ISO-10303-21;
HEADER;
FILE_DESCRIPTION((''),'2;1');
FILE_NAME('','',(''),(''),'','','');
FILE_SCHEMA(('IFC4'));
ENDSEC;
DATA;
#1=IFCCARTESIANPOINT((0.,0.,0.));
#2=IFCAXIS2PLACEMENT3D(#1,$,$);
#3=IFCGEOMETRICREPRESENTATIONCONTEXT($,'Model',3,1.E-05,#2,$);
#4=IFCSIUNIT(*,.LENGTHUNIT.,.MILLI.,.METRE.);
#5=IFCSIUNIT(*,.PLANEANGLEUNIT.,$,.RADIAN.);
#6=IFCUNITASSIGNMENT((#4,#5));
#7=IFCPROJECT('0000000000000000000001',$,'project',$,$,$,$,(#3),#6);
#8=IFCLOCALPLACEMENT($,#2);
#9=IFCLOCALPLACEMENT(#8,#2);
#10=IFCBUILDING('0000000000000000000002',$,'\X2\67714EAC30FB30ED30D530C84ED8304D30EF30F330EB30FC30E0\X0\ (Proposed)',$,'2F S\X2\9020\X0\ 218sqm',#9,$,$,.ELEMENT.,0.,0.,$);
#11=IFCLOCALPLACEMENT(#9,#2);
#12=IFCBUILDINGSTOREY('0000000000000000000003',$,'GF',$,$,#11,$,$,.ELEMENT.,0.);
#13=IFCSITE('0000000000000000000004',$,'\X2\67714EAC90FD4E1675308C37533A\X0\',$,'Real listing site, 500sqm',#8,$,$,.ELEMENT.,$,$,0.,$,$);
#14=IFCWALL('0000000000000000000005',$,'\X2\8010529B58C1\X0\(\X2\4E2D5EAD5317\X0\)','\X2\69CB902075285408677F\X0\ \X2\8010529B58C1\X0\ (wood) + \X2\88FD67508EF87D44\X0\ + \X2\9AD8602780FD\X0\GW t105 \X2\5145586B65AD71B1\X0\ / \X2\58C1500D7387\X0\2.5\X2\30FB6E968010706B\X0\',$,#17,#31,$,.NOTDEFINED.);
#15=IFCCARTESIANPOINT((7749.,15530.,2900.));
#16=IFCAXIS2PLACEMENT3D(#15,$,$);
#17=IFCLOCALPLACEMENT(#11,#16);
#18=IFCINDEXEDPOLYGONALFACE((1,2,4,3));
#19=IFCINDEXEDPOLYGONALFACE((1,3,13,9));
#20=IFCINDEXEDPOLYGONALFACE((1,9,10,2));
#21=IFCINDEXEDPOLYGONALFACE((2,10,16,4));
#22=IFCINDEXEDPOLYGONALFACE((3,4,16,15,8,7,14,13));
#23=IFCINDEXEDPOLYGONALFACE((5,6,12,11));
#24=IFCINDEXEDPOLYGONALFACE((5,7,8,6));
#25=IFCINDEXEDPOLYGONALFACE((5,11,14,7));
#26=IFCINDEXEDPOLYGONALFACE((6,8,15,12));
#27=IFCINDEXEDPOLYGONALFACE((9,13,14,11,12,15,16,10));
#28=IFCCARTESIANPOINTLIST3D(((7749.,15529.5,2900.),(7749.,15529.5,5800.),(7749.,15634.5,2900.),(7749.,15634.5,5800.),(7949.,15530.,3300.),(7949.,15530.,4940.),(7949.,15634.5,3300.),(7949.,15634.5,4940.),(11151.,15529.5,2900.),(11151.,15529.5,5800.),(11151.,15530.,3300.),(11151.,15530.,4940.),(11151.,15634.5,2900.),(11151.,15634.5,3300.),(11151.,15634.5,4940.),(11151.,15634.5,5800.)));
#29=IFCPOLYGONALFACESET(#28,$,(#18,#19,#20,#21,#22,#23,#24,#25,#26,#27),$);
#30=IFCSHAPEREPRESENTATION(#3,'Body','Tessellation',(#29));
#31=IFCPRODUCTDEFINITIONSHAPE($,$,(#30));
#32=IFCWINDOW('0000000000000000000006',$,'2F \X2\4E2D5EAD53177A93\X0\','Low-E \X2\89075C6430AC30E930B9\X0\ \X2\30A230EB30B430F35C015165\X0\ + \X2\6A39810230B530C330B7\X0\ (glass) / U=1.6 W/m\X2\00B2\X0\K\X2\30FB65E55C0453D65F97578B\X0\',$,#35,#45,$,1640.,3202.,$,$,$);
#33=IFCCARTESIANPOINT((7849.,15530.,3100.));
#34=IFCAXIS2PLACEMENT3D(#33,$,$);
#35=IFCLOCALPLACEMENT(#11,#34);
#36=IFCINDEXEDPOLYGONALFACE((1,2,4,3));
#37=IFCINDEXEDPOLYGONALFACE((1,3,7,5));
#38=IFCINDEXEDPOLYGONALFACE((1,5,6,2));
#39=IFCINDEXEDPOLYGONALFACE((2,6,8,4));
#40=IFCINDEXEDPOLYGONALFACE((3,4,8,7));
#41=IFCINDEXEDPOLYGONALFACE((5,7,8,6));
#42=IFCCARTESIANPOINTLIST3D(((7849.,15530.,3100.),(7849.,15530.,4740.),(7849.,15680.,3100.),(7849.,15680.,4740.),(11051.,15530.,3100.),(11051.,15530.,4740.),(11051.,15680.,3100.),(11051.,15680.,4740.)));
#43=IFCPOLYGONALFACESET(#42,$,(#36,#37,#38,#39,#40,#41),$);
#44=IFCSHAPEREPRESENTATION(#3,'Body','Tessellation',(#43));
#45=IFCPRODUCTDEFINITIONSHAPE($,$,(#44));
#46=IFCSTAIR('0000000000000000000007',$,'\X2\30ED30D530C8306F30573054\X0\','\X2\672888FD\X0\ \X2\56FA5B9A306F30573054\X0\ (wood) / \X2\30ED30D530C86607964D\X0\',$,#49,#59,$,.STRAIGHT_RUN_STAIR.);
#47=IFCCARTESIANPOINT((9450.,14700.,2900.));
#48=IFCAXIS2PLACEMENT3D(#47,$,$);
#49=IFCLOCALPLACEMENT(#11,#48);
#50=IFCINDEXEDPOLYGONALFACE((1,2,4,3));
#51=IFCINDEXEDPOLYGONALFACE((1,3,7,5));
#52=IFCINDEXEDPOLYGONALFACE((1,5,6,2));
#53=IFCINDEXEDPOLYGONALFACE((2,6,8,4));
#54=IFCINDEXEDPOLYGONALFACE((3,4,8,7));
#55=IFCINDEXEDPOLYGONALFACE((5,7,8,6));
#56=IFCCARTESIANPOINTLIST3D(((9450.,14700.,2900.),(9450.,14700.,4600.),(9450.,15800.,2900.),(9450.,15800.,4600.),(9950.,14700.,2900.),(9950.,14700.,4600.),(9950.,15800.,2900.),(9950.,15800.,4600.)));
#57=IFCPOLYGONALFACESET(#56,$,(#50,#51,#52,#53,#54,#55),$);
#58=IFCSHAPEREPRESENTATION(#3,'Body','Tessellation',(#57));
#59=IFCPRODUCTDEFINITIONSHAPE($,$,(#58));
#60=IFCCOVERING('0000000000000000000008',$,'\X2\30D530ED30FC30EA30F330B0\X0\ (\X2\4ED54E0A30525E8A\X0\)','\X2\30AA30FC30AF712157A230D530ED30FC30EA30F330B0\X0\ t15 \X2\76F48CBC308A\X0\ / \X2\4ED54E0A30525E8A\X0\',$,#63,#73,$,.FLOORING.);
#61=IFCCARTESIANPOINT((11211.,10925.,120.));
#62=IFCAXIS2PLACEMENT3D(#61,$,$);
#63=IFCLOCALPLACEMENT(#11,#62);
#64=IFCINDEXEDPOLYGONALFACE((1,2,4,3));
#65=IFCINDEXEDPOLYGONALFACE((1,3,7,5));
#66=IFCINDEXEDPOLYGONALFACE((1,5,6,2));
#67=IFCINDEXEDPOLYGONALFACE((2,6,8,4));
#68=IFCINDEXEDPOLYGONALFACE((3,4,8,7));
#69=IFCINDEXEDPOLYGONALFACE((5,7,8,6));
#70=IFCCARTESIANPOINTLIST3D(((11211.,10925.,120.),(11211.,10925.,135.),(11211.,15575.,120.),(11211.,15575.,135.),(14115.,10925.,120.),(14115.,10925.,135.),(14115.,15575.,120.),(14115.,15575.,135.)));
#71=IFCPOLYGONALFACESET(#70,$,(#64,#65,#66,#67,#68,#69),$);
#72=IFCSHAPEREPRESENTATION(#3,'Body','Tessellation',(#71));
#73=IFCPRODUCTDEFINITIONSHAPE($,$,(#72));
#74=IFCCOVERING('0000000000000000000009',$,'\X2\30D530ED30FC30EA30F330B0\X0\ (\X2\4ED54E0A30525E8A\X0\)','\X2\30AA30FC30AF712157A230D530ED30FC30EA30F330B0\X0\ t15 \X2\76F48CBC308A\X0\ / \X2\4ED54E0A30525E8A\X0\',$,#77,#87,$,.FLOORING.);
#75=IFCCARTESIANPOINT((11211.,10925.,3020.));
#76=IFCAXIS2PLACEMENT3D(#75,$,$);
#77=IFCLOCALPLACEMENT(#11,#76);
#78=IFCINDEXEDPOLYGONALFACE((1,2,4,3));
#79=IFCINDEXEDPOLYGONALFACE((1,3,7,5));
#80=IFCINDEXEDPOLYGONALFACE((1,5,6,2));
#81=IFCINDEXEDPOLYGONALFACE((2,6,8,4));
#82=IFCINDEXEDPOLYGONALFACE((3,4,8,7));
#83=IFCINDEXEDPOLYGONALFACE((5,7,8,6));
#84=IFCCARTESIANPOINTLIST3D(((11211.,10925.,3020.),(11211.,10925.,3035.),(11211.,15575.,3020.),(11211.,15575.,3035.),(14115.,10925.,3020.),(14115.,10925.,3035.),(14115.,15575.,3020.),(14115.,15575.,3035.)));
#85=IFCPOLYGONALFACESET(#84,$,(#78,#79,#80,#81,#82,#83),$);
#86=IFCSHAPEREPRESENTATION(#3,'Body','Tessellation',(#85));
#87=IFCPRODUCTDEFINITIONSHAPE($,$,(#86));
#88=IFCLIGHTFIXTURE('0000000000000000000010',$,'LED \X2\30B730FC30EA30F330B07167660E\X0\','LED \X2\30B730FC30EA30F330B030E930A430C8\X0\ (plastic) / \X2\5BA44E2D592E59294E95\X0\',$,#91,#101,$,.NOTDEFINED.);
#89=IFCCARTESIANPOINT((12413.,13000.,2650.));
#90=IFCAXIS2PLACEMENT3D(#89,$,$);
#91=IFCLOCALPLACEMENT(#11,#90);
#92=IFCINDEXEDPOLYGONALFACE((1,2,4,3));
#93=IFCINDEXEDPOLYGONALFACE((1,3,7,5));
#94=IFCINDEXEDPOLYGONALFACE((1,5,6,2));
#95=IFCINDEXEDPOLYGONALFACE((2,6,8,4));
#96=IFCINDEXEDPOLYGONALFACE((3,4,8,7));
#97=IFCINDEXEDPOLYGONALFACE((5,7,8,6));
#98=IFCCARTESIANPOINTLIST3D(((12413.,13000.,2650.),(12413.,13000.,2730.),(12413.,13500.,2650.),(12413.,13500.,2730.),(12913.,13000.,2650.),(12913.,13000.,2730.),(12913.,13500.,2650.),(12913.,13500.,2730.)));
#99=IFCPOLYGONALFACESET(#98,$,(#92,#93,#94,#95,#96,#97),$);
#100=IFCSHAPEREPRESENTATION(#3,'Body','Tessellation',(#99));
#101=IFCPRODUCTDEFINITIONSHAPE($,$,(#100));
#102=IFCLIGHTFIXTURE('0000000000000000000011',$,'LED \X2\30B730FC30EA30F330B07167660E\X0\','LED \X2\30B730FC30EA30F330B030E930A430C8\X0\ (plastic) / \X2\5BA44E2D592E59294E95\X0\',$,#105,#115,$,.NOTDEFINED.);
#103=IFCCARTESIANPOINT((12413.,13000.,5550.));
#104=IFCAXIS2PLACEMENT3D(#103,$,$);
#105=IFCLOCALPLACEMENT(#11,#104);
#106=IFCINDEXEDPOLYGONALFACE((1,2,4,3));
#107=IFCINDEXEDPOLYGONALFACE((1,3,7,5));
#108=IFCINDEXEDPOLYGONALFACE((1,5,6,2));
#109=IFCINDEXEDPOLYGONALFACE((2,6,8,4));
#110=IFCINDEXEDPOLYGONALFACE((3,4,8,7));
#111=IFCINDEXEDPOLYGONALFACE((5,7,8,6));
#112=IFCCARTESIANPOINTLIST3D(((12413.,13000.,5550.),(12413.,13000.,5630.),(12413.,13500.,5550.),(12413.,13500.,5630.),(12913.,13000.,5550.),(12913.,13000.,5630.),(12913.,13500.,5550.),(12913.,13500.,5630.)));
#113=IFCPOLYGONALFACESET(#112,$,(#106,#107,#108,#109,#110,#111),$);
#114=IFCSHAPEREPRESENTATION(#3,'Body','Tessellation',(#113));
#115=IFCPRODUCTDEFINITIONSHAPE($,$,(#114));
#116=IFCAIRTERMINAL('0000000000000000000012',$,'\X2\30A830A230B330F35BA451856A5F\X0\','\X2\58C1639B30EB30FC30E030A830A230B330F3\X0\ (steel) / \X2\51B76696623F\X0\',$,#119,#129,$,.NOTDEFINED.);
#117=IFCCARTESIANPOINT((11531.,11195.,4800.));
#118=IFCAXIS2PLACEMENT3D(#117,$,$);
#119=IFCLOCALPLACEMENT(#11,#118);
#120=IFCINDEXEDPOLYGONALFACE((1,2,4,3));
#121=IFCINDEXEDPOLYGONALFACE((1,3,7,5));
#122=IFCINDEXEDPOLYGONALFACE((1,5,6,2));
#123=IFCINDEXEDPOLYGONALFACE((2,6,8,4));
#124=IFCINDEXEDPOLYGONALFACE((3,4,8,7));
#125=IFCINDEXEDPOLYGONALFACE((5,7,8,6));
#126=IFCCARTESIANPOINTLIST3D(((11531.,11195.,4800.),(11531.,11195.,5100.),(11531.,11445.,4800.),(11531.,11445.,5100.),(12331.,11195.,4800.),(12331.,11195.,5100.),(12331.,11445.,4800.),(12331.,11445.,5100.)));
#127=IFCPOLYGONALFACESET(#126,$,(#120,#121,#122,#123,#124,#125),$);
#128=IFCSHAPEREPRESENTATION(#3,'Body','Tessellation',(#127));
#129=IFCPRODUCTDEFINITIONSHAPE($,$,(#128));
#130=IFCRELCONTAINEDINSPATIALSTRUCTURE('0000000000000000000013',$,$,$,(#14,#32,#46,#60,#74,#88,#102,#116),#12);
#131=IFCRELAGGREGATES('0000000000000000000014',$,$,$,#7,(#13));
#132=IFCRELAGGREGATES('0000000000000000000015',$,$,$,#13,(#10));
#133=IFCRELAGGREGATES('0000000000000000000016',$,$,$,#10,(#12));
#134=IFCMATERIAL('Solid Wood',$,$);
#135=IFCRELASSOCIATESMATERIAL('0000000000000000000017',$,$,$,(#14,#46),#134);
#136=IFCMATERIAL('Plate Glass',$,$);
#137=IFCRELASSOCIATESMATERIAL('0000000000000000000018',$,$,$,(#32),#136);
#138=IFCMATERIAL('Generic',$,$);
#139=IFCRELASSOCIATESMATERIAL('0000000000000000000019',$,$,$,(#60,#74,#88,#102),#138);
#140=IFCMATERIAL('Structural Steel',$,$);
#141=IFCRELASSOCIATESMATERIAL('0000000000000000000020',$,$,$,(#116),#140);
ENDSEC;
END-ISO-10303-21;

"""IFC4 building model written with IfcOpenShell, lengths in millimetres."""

from ifc_helpers import new_model, si_unit, frame, frame_2d, origin, place, context, project, spatial, rectangle, extrude, material, element, fill, save


model = new_model("IFC4")

# Units and contexts
model_context = context("Model", 3, precision=1e-05, world=origin())
ifc_project = project(units=[si_unit("LENGTHUNIT", "METRE", prefix="MILLI"), si_unit("PLANEANGLEUNIT", "RADIAN")], contexts=[model_context])

# Site, building, storey
site_placement = place(None, origin())
site = spatial("IfcSite", under=ifc_project, at=site_placement, Name="東京都世田谷区", ObjectType="Real listing site, 500sqm", CompositionType="ELEMENT", RefElevation=0.0)
building_placement = place(site_placement, origin())
building = spatial("IfcBuilding", under=site, at=building_placement, Name="東京・ロフト付きワンルーム (Proposed)", ObjectType="2F S造 218sqm", CompositionType="ELEMENT", ElevationOfRefHeight=0.0, ElevationOfTerrain=0.0)
storey_placement = place(building_placement, origin())
storey = spatial("IfcBuildingStorey", under=building, at=storey_placement, Name="GF", CompositionType="ELEMENT", Elevation=0.0)

# Shared definitions
ifc_material_1 = material(Name="Solid Wood")

# Wall, opening, window
ifc_material_2 = material(Name="Plate Glass")
wall_1_placement = place(storey_placement, frame((7749.0, 15530.0, 2900.0)))
wall_1 = element("IfcWall", 1, at=wall_1_placement, inside=storey, material=ifc_material_1, Name="耐力壁(中庭北)", Description="構造用合板 耐力壁 (wood) + 製材軸組 + 高性能GW t105 充填断熱 / 壁倍率2.5・準耐火", PredefinedType="NOTDEFINED", context=model_context, shape_type="SweptSolid", body=[
    extrude(rectangle(XDim=3402.0, YDim=105.0, at=frame_2d((1701.0, 52.0))), frame((7749.0, 15530.0, 2900.0)), (0.0, 0.0, 1.0), 2900.0),
])
opening_1_placement = place(storey_placement, frame((7849.0, 15530.0, 3100.0)))
opening_1 = element("IfcOpeningElement", 2, at=opening_1_placement, cuts=wall_1, PredefinedType="NOTDEFINED", context=model_context, shape_type="SweptSolid", body=[
    extrude(rectangle(XDim=3202.0, YDim=150.0, at=frame_2d((1601.0, 75.0))), frame((7849.0, 15530.0, 3100.0)), (0.0, 0.0, 1.0), 1640.0),
])
window_1_placement = place(storey_placement, frame((7849.0, 15530.0, 3100.0)))
window_1 = element("IfcWindow", 3, at=window_1_placement, inside=storey, material=ifc_material_2, Name="2F 中庭北窓", Description="Low-E 複層ガラス アルゴン封入 + 樹脂サッシ (glass) / U=1.6 W/m²K・日射取得型", OverallHeight=1640.0, OverallWidth=3202.0, context=model_context, shape_type="SweptSolid", body=[
    extrude(rectangle(XDim=3202.0, YDim=150.0, at=frame_2d((1601.0, 75.0))), frame((7849.0, 15530.0, 3100.0)), (0.0, 0.0, 1.0), 1640.0),
])
fill(opening_1, window_1)

# Stair
stair_placement = place(storey_placement, frame((9450.0, 14700.0, 2900.0)))
element("IfcStair", 4, at=stair_placement, inside=storey, material=ifc_material_1, Name="ロフトはしご", Description="木製 固定はしご (wood) / ロフト昇降", PredefinedType="STRAIGHT_RUN_STAIR", context=model_context, shape_type="SweptSolid", body=[
    extrude(rectangle(XDim=500.0, YDim=1100.0, at=frame_2d((250.0, 550.0))), frame((9450.0, 14700.0, 2900.0)), (0.0, 0.0, 1.0), 1700.0),
])

# Coverings
ifc_material_3 = material(Name="Generic")
covering_1_placement = place(storey_placement, frame((11211.0, 10925.0, 120.0)))
element("IfcCovering", 5, at=covering_1_placement, inside=storey, material=ifc_material_3, Name="フローリング (仕上げ床)", Description="オーク無垢フローリング t15 直貼り / 仕上げ床", PredefinedType="FLOORING", context=model_context, shape_type="SweptSolid", body=[
    extrude(rectangle(XDim=2904.0, YDim=4650.0, at=frame_2d((1452.0, 2325.0))), frame((11211.0, 10925.0, 120.0)), (0.0, 0.0, 1.0), 15.0),
])
covering_2_placement = place(storey_placement, frame((11211.0, 10925.0, 3020.0)))
element("IfcCovering", 6, at=covering_2_placement, inside=storey, material=ifc_material_3, Name="フローリング (仕上げ床)", Description="オーク無垢フローリング t15 直貼り / 仕上げ床", PredefinedType="FLOORING", context=model_context, shape_type="SweptSolid", body=[
    extrude(rectangle(XDim=2904.0, YDim=4650.0, at=frame_2d((1452.0, 2325.0))), frame((11211.0, 10925.0, 3020.0)), (0.0, 0.0, 1.0), 15.0),
])

# Light fixtures
light_fixture_1_placement = place(storey_placement, frame((12413.0, 13000.0, 2650.0)))
element("IfcLightFixture", 7, at=light_fixture_1_placement, inside=storey, material=ifc_material_3, Name="LED シーリング照明", Description="LED シーリングライト (plastic) / 室中央天井", PredefinedType="NOTDEFINED", context=model_context, shape_type="SweptSolid", body=[
    extrude(rectangle(XDim=500.0, YDim=500.0, at=frame_2d((250.0, 250.0))), frame((12413.0, 13000.0, 2650.0)), (0.0, 0.0, 1.0), 80.0),
])
light_fixture_2_placement = place(storey_placement, frame((12413.0, 13000.0, 5550.0)))
element("IfcLightFixture", 8, at=light_fixture_2_placement, inside=storey, material=ifc_material_3, Name="LED シーリング照明", Description="LED シーリングライト (plastic) / 室中央天井", PredefinedType="NOTDEFINED", context=model_context, shape_type="SweptSolid", body=[
    extrude(rectangle(XDim=500.0, YDim=500.0, at=frame_2d((250.0, 250.0))), frame((12413.0, 13000.0, 5550.0)), (0.0, 0.0, 1.0), 80.0),
])

# Air terminal
ifc_material_4 = material(Name="Structural Steel")
air_terminal_placement = place(storey_placement, frame((11531.0, 11195.0, 4800.0)))
element("IfcAirTerminal", 9, at=air_terminal_placement, inside=storey, material=ifc_material_4, Name="エアコン室内機", Description="壁掛ルームエアコン (steel) / 冷暖房", PredefinedType="NOTDEFINED", context=model_context, shape_type="SweptSolid", body=[
    extrude(rectangle(XDim=800.0, YDim=250.0, at=frame_2d((400.0, 125.0))), frame((11531.0, 11195.0, 4800.0)), (0.0, 0.0, 1.0), 300.0),
])

save(model, "model.ifc")
